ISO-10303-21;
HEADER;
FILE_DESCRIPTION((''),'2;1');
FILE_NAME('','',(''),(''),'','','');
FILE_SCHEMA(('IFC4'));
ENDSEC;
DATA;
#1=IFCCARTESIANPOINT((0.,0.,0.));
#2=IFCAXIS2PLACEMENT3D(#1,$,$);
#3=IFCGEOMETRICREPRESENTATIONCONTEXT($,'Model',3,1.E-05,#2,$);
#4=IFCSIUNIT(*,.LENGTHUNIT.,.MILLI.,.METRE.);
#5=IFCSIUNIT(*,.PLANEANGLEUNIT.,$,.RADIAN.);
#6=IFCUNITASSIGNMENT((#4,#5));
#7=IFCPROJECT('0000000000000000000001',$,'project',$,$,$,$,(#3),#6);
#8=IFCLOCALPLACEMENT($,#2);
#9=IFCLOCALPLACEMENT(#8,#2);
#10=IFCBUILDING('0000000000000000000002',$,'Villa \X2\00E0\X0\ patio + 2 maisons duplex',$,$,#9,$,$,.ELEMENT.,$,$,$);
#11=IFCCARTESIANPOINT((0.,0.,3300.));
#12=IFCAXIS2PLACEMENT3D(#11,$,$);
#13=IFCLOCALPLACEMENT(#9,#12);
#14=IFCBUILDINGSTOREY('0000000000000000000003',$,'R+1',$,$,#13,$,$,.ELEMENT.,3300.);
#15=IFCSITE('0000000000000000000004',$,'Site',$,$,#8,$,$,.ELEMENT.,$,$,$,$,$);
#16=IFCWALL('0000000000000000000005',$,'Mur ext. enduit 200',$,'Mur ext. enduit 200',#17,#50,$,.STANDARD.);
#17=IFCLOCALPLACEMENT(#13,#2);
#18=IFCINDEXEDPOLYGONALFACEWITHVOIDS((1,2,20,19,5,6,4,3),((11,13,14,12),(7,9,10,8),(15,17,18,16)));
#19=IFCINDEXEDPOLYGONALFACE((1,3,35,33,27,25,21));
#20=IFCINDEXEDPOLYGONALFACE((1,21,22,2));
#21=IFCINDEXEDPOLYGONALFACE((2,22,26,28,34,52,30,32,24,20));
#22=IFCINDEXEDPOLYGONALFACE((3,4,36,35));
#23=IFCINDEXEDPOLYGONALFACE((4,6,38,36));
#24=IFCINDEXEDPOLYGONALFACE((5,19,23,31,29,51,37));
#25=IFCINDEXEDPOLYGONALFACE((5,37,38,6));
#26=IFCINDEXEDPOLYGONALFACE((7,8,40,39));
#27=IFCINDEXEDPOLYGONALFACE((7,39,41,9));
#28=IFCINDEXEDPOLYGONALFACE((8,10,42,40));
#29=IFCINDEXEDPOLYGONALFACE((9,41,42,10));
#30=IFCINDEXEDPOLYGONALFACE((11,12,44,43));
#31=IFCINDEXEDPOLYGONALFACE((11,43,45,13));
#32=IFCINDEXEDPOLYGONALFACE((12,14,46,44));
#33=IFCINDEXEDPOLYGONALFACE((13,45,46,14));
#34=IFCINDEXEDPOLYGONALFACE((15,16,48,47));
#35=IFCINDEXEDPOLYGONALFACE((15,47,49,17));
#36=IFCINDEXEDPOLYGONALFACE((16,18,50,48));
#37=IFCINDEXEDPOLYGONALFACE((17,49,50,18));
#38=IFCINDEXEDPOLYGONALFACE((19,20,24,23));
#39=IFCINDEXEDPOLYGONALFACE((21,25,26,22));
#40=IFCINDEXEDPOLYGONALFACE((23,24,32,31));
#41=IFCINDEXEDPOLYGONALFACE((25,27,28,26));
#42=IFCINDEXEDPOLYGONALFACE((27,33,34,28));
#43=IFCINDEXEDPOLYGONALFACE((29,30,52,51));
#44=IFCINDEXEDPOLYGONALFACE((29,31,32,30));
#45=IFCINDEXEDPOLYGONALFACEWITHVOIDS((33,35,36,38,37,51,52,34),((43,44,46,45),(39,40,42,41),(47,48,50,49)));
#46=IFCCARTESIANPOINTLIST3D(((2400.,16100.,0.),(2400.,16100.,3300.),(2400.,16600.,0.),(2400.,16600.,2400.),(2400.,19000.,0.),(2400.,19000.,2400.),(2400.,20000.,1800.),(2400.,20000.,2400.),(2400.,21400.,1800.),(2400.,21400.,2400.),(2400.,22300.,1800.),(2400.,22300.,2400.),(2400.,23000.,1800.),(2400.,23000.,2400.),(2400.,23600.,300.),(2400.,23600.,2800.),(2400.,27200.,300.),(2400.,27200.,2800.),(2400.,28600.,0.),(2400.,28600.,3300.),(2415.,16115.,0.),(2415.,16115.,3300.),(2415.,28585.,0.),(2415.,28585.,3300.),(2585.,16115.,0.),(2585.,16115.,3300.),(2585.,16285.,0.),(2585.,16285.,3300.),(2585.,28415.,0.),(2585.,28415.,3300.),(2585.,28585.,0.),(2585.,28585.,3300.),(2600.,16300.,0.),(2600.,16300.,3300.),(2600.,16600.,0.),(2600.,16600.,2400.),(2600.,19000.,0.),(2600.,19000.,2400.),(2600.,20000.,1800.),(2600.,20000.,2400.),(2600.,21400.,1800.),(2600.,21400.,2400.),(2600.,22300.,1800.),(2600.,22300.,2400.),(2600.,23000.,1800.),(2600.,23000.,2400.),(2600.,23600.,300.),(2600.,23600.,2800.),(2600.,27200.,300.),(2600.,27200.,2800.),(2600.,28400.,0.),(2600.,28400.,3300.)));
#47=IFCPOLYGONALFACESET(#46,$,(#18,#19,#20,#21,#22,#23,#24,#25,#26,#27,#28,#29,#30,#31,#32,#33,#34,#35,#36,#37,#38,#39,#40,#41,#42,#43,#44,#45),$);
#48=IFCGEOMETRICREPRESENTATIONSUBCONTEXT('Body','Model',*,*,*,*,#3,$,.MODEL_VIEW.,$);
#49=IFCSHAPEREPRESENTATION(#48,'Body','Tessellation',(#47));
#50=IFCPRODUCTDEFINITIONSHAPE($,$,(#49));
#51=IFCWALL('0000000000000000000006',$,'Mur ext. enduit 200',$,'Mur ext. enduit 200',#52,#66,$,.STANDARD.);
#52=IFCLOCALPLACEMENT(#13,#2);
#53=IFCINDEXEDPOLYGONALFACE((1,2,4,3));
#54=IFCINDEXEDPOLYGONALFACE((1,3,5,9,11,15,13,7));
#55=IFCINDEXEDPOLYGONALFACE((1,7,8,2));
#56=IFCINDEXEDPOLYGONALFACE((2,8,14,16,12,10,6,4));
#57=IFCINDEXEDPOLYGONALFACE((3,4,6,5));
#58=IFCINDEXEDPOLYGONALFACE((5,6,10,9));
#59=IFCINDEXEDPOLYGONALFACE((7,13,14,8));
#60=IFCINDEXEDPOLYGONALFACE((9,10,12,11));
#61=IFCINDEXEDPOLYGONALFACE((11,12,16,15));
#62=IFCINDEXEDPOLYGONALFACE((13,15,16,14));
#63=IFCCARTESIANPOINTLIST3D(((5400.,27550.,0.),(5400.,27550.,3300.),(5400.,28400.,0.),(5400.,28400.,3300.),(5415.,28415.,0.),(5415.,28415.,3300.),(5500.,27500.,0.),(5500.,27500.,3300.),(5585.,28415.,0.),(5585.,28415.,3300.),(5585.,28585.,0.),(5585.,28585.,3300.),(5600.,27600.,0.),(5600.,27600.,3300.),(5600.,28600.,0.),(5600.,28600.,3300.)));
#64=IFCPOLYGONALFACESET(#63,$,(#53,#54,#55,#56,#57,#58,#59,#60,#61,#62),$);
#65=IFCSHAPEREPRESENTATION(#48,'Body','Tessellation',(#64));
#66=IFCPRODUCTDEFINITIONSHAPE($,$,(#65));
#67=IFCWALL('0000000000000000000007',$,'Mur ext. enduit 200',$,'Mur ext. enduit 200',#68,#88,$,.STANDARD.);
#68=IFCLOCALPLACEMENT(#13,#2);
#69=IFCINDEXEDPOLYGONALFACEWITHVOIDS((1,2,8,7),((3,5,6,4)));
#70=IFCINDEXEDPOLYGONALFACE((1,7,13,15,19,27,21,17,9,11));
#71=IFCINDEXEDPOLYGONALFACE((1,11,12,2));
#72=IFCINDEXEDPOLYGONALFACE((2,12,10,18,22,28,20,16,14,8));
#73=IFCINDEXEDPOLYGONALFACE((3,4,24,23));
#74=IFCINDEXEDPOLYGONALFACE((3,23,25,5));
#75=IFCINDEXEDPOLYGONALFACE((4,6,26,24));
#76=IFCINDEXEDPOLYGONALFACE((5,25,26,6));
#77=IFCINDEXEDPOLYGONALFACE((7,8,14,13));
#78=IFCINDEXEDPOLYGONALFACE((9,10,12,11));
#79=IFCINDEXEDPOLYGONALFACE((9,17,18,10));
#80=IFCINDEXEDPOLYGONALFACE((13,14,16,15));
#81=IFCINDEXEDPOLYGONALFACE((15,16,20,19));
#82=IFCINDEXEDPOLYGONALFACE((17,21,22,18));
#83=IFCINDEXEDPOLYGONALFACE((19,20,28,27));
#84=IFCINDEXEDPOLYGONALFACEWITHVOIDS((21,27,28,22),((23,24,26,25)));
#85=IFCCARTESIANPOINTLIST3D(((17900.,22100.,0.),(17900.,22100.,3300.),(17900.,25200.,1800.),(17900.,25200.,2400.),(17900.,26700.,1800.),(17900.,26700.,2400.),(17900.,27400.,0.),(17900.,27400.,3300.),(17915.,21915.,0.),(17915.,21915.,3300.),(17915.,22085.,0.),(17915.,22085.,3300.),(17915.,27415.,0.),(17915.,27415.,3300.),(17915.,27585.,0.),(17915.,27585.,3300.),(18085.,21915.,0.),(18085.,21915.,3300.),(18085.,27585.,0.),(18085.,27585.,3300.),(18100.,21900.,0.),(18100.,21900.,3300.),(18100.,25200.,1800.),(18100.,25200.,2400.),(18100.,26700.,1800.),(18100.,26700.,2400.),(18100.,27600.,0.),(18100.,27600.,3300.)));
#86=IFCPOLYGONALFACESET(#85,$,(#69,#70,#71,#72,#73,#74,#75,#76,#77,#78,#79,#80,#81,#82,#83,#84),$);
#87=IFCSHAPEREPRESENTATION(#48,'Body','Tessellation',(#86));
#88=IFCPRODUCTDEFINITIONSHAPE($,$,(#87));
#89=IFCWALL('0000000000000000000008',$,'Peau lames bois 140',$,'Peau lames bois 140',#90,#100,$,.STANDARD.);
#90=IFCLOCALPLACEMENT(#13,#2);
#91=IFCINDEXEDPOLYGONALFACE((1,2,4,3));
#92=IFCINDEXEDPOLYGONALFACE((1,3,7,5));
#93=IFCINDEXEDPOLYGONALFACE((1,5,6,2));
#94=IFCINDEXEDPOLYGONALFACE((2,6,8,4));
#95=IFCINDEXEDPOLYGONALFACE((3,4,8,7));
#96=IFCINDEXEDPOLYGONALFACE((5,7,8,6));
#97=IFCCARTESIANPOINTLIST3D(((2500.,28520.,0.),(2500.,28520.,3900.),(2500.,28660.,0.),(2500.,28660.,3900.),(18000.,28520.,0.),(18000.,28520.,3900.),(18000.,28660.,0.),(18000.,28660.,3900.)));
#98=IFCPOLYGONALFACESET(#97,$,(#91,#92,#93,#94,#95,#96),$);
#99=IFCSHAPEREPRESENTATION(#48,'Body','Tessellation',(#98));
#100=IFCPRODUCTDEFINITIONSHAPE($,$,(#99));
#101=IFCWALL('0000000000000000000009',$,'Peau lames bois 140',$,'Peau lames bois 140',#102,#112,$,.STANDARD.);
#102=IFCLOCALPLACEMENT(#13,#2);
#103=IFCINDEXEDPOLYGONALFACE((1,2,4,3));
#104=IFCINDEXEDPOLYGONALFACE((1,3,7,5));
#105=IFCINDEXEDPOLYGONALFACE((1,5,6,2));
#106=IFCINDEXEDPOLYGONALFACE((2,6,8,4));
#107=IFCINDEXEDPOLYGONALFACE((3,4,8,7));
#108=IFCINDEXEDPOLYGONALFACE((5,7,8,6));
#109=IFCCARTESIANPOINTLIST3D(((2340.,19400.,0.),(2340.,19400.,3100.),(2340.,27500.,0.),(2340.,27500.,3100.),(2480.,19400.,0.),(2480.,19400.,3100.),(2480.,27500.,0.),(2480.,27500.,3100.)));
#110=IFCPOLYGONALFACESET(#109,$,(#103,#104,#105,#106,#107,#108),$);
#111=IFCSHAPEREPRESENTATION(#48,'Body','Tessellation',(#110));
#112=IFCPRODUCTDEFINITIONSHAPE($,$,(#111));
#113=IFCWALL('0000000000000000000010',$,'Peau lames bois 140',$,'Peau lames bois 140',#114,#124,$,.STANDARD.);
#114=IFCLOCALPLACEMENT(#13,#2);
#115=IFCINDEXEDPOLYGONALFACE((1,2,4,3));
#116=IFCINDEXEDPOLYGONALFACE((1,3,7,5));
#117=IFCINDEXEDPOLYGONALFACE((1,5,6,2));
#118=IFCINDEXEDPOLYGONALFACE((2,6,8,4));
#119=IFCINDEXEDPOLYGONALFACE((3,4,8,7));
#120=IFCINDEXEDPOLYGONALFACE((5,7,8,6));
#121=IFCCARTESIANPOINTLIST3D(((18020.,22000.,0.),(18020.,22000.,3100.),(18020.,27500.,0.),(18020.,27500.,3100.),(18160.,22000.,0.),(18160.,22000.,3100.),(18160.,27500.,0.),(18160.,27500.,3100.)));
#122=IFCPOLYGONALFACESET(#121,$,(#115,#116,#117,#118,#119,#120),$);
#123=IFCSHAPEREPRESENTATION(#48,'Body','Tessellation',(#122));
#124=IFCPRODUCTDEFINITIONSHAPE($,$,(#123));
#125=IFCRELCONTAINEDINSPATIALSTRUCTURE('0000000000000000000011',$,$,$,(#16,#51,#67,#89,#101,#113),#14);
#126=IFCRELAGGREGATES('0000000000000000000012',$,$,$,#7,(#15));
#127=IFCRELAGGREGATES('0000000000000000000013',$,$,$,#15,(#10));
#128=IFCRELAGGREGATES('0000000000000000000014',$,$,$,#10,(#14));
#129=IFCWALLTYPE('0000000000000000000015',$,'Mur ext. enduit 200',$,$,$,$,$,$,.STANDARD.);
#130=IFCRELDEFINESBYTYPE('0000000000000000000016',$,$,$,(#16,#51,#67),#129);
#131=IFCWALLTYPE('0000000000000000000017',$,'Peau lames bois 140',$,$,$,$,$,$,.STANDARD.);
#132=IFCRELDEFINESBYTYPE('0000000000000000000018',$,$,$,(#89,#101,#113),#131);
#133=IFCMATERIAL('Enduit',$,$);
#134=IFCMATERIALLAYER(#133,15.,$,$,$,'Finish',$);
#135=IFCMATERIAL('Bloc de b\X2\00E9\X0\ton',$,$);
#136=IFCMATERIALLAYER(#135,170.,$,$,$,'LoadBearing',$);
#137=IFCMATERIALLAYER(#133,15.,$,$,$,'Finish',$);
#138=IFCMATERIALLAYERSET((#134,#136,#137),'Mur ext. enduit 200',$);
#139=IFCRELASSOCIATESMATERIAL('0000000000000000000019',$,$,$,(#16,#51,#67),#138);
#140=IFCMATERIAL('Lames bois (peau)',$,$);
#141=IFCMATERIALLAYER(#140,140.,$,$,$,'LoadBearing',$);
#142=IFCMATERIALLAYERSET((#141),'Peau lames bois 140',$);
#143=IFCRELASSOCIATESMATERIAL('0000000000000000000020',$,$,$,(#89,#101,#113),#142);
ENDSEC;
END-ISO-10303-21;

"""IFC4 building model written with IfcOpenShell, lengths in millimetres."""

from ifc_helpers import new_model, si_unit, frame, frame_2d, origin, place, context, subcontext, project, spatial, polyline, rectangle, outline, extrude, material, layer, layer_set, layer_usage, type_object, element, save


model = new_model("IFC4")

# Units and contexts
model_context = context("Model", 3, precision=1e-05, world=origin())
body_context = subcontext(model_context, "Body", "Model", "MODEL_VIEW")
ifc_project = project(units=[si_unit("LENGTHUNIT", "METRE", prefix="MILLI"), si_unit("PLANEANGLEUNIT", "RADIAN")], contexts=[model_context])

# Site, building, storey
site_placement = place(None, origin())
site = spatial("IfcSite", under=ifc_project, at=site_placement, Name="Site", CompositionType="ELEMENT")
building_placement = place(site_placement, origin())
building = spatial("IfcBuilding", under=site, at=building_placement, Name="Villa à patio + 2 maisons duplex", CompositionType="ELEMENT")
storey_placement = place(building_placement, frame((0.0, 0.0, 3300.0)))
storey = spatial("IfcBuildingStorey", under=building, at=storey_placement, Name="R+1", CompositionType="ELEMENT", Elevation=3300.0)

# Shared definitions
ifc_material_1 = material(Name="Enduit")
ifc_material_2 = material(Name="Bloc de béton")

# Shared definitions
ifc_layer_1 = layer(ifc_material_1, 15.0, Category="Finish")
ifc_layer_2 = layer(ifc_material_2, 170.0, Category="LoadBearing")
ifc_layer_3 = layer(ifc_material_1, 15.0, Category="Finish")
ifc_layer_set_1 = layer_set([ifc_layer_1, ifc_layer_2, ifc_layer_3], Name="Mur ext. enduit 200")
ifc_layer_usage_1 = layer_usage(ifc_layer_set_1, "AXIS2", "NEGATIVE", 100.0)
wall_type_1 = type_object("IfcWallType", Name="Mur ext. enduit 200", PredefinedType="STANDARD")

# Wall, openings
wall_1_placement = place(storey_placement, frame((2500.0, 28500.0, 0.0), z_axis=(0.0, 0.0, 1.0), x_axis=(0.0, -1.0, 0.0)))
wall_1 = element("IfcWall", 1, at=wall_1_placement, inside=storey, type_object=wall_type_1, material=ifc_layer_usage_1, Name="Mur ext. enduit 200", ObjectType="Mur ext. enduit 200", PredefinedType="STANDARD", context=body_context, shape_type="SweptSolid", body=[
    extrude(outline(polyline([(-100.0, -100.0), (-85.0, -85.0), (-85.0, 85.0), (85.0, 85.0), (100.0, 100.0), (12200.0, 100.0), (12215.0, 85.0), (12385.0, 85.0), (12385.0, -85.0), (12400.0, -100.0), (-100.0, -100.0)])), origin(), (0.0, 0.0, 1.0), 3300.0),
])
opening_1_placement = place(wall_1_placement, frame((1300.0, 0.0, 300.0), z_axis=(0.0, 0.0, 1.0), x_axis=(1.0, 0.0, 0.0)))
element("IfcOpeningElement", 2, at=opening_1_placement, cuts=wall_1, PredefinedType="OPENING", context=body_context, shape_type="SweptSolid", body=[
    extrude(rectangle(XDim=3600.0, YDim=220.0, at=frame_2d((1800.0, 0.0))), origin(), (0.0, 0.0, 1.0), 2500.0),
])
opening_2_placement = place(wall_1_placement, frame((5500.0, 0.0, 1800.0), z_axis=(0.0, 0.0, 1.0), x_axis=(1.0, 0.0, 0.0)))
element("IfcOpeningElement", 3, at=opening_2_placement, cuts=wall_1, PredefinedType="OPENING", context=body_context, shape_type="SweptSolid", body=[
    extrude(rectangle(XDim=700.0, YDim=220.0, at=frame_2d((350.0, 0.0))), origin(), (0.0, 0.0, 1.0), 600.0),
])
opening_3_placement = place(wall_1_placement, frame((7100.0, 0.0, 1800.0), z_axis=(0.0, 0.0, 1.0), x_axis=(1.0, 0.0, 0.0)))
element("IfcOpeningElement", 4, at=opening_3_placement, cuts=wall_1, PredefinedType="OPENING", context=body_context, shape_type="SweptSolid", body=[
    extrude(rectangle(XDim=1400.0, YDim=220.0, at=frame_2d((700.0, 0.0))), origin(), (0.0, 0.0, 1.0), 600.0),
])
opening_4_placement = place(wall_1_placement, frame((9500.0, 0.0, 0.0), z_axis=(0.0, 0.0, 1.0), x_axis=(1.0, 0.0, 0.0)))
element("IfcOpeningElement", 5, at=opening_4_placement, cuts=wall_1, PredefinedType="OPENING", context=body_context, shape_type="SweptSolid", body=[
    extrude(rectangle(XDim=2400.0, YDim=220.0, at=frame_2d((1200.0, 0.0))), origin(), (0.0, 0.0, 1.0), 2400.0),
])

# Wall
wall_2_placement = place(storey_placement, frame((5500.0, 28500.0, 0.0), z_axis=(0.0, 0.0, 1.0), x_axis=(0.0, -1.0, 0.0)))
element("IfcWall", 6, at=wall_2_placement, inside=storey, type_object=wall_type_1, material=ifc_layer_usage_1, Name="Mur ext. enduit 200", ObjectType="Mur ext. enduit 200", PredefinedType="STANDARD", context=body_context, shape_type="SweptSolid", body=[
    extrude(outline(polyline([(100.0, -100.0), (85.0, -85.0), (85.0, 85.0), (-85.0, 85.0), (-100.0, 100.0), (900.0, 100.0), (1000.0, 0.0), (950.0, -100.0), (100.0, -100.0)])), origin(), (0.0, 0.0, 1.0), 3300.0),
])

# Wall, opening
wall_3_placement = place(storey_placement, frame((18000.0, 27500.0, 0.0), z_axis=(0.0, 0.0, 1.0), x_axis=(0.0, -1.0, 0.0)))
wall_3 = element("IfcWall", 7, at=wall_3_placement, inside=storey, type_object=wall_type_1, material=ifc_layer_usage_1, Name="Mur ext. enduit 200", ObjectType="Mur ext. enduit 200", PredefinedType="STANDARD", context=body_context, shape_type="SweptSolid", body=[
    extrude(outline(polyline([(100.0, -100.0), (85.0, -85.0), (-85.0, -85.0), (-85.0, 85.0), (-100.0, 100.0), (5600.0, 100.0), (5585.0, 85.0), (5585.0, -85.0), (5415.0, -85.0), (5400.0, -100.0), (100.0, -100.0)])), origin(), (0.0, 0.0, 1.0), 3300.0),
])
opening_5_placement = place(wall_3_placement, frame((800.0, 0.0, 1800.0), z_axis=(0.0, 0.0, 1.0), x_axis=(1.0, 0.0, 0.0)))
element("IfcOpeningElement", 8, at=opening_5_placement, cuts=wall_3, PredefinedType="OPENING", context=body_context, shape_type="SweptSolid", body=[
    extrude(rectangle(XDim=1500.0, YDim=220.0, at=frame_2d((750.0, 0.0))), origin(), (0.0, 0.0, 1.0), 600.0),
])

# Walls
ifc_material_3 = material(Name="Lames bois (peau)")
ifc_layer_4 = layer(ifc_material_3, 140.0, Category="LoadBearing")
ifc_layer_set_2 = layer_set([ifc_layer_4], Name="Peau lames bois 140")
ifc_layer_usage_2 = layer_usage(ifc_layer_set_2, "AXIS2", "NEGATIVE", 70.0)
wall_type_2 = type_object("IfcWallType", Name="Peau lames bois 140", PredefinedType="STANDARD")
wall_4_placement = place(storey_placement, frame((2500.0, 28590.0, 0.0), z_axis=(0.0, 0.0, 1.0), x_axis=(1.0, 0.0, 0.0)))
element("IfcWall", 9, at=wall_4_placement, inside=storey, type_object=wall_type_2, material=ifc_layer_usage_2, Name="Peau lames bois 140", ObjectType="Peau lames bois 140", PredefinedType="STANDARD", context=body_context, shape_type="SweptSolid", body=[
    extrude(outline(polyline([(0.0, -70.0), (0.0, 70.0), (15500.0, 70.0), (15500.0, -70.0), (0.0, -70.0)])), origin(), (0.0, 0.0, 1.0), 3900.0),
])
wall_5_placement = place(storey_placement, frame((2410.0, 27500.0, 0.0), z_axis=(0.0, 0.0, 1.0), x_axis=(0.0, -1.0, 0.0)))
element("IfcWall", 10, at=wall_5_placement, inside=storey, type_object=wall_type_2, material=ifc_layer_usage_2, Name="Peau lames bois 140", ObjectType="Peau lames bois 140", PredefinedType="STANDARD", context=body_context, shape_type="SweptSolid", body=[
    extrude(outline(polyline([(0.0, -70.0), (0.0, 70.0), (8100.0, 70.0), (8100.0, -70.0), (0.0, -70.0)])), origin(), (0.0, 0.0, 1.0), 3100.0),
])
wall_6_placement = place(storey_placement, frame((18090.0, 27500.0, 0.0), z_axis=(0.0, 0.0, 1.0), x_axis=(0.0, -1.0, 0.0)))
element("IfcWall", 11, at=wall_6_placement, inside=storey, type_object=wall_type_2, material=ifc_layer_usage_2, Name="Peau lames bois 140", ObjectType="Peau lames bois 140", PredefinedType="STANDARD", context=body_context, shape_type="SweptSolid", body=[
    extrude(outline(polyline([(0.0, -70.0), (0.0, 70.0), (5500.0, 70.0), (5500.0, -70.0), (0.0, -70.0)])), origin(), (0.0, 0.0, 1.0), 3100.0),
])

save(model, "model.ifc")
